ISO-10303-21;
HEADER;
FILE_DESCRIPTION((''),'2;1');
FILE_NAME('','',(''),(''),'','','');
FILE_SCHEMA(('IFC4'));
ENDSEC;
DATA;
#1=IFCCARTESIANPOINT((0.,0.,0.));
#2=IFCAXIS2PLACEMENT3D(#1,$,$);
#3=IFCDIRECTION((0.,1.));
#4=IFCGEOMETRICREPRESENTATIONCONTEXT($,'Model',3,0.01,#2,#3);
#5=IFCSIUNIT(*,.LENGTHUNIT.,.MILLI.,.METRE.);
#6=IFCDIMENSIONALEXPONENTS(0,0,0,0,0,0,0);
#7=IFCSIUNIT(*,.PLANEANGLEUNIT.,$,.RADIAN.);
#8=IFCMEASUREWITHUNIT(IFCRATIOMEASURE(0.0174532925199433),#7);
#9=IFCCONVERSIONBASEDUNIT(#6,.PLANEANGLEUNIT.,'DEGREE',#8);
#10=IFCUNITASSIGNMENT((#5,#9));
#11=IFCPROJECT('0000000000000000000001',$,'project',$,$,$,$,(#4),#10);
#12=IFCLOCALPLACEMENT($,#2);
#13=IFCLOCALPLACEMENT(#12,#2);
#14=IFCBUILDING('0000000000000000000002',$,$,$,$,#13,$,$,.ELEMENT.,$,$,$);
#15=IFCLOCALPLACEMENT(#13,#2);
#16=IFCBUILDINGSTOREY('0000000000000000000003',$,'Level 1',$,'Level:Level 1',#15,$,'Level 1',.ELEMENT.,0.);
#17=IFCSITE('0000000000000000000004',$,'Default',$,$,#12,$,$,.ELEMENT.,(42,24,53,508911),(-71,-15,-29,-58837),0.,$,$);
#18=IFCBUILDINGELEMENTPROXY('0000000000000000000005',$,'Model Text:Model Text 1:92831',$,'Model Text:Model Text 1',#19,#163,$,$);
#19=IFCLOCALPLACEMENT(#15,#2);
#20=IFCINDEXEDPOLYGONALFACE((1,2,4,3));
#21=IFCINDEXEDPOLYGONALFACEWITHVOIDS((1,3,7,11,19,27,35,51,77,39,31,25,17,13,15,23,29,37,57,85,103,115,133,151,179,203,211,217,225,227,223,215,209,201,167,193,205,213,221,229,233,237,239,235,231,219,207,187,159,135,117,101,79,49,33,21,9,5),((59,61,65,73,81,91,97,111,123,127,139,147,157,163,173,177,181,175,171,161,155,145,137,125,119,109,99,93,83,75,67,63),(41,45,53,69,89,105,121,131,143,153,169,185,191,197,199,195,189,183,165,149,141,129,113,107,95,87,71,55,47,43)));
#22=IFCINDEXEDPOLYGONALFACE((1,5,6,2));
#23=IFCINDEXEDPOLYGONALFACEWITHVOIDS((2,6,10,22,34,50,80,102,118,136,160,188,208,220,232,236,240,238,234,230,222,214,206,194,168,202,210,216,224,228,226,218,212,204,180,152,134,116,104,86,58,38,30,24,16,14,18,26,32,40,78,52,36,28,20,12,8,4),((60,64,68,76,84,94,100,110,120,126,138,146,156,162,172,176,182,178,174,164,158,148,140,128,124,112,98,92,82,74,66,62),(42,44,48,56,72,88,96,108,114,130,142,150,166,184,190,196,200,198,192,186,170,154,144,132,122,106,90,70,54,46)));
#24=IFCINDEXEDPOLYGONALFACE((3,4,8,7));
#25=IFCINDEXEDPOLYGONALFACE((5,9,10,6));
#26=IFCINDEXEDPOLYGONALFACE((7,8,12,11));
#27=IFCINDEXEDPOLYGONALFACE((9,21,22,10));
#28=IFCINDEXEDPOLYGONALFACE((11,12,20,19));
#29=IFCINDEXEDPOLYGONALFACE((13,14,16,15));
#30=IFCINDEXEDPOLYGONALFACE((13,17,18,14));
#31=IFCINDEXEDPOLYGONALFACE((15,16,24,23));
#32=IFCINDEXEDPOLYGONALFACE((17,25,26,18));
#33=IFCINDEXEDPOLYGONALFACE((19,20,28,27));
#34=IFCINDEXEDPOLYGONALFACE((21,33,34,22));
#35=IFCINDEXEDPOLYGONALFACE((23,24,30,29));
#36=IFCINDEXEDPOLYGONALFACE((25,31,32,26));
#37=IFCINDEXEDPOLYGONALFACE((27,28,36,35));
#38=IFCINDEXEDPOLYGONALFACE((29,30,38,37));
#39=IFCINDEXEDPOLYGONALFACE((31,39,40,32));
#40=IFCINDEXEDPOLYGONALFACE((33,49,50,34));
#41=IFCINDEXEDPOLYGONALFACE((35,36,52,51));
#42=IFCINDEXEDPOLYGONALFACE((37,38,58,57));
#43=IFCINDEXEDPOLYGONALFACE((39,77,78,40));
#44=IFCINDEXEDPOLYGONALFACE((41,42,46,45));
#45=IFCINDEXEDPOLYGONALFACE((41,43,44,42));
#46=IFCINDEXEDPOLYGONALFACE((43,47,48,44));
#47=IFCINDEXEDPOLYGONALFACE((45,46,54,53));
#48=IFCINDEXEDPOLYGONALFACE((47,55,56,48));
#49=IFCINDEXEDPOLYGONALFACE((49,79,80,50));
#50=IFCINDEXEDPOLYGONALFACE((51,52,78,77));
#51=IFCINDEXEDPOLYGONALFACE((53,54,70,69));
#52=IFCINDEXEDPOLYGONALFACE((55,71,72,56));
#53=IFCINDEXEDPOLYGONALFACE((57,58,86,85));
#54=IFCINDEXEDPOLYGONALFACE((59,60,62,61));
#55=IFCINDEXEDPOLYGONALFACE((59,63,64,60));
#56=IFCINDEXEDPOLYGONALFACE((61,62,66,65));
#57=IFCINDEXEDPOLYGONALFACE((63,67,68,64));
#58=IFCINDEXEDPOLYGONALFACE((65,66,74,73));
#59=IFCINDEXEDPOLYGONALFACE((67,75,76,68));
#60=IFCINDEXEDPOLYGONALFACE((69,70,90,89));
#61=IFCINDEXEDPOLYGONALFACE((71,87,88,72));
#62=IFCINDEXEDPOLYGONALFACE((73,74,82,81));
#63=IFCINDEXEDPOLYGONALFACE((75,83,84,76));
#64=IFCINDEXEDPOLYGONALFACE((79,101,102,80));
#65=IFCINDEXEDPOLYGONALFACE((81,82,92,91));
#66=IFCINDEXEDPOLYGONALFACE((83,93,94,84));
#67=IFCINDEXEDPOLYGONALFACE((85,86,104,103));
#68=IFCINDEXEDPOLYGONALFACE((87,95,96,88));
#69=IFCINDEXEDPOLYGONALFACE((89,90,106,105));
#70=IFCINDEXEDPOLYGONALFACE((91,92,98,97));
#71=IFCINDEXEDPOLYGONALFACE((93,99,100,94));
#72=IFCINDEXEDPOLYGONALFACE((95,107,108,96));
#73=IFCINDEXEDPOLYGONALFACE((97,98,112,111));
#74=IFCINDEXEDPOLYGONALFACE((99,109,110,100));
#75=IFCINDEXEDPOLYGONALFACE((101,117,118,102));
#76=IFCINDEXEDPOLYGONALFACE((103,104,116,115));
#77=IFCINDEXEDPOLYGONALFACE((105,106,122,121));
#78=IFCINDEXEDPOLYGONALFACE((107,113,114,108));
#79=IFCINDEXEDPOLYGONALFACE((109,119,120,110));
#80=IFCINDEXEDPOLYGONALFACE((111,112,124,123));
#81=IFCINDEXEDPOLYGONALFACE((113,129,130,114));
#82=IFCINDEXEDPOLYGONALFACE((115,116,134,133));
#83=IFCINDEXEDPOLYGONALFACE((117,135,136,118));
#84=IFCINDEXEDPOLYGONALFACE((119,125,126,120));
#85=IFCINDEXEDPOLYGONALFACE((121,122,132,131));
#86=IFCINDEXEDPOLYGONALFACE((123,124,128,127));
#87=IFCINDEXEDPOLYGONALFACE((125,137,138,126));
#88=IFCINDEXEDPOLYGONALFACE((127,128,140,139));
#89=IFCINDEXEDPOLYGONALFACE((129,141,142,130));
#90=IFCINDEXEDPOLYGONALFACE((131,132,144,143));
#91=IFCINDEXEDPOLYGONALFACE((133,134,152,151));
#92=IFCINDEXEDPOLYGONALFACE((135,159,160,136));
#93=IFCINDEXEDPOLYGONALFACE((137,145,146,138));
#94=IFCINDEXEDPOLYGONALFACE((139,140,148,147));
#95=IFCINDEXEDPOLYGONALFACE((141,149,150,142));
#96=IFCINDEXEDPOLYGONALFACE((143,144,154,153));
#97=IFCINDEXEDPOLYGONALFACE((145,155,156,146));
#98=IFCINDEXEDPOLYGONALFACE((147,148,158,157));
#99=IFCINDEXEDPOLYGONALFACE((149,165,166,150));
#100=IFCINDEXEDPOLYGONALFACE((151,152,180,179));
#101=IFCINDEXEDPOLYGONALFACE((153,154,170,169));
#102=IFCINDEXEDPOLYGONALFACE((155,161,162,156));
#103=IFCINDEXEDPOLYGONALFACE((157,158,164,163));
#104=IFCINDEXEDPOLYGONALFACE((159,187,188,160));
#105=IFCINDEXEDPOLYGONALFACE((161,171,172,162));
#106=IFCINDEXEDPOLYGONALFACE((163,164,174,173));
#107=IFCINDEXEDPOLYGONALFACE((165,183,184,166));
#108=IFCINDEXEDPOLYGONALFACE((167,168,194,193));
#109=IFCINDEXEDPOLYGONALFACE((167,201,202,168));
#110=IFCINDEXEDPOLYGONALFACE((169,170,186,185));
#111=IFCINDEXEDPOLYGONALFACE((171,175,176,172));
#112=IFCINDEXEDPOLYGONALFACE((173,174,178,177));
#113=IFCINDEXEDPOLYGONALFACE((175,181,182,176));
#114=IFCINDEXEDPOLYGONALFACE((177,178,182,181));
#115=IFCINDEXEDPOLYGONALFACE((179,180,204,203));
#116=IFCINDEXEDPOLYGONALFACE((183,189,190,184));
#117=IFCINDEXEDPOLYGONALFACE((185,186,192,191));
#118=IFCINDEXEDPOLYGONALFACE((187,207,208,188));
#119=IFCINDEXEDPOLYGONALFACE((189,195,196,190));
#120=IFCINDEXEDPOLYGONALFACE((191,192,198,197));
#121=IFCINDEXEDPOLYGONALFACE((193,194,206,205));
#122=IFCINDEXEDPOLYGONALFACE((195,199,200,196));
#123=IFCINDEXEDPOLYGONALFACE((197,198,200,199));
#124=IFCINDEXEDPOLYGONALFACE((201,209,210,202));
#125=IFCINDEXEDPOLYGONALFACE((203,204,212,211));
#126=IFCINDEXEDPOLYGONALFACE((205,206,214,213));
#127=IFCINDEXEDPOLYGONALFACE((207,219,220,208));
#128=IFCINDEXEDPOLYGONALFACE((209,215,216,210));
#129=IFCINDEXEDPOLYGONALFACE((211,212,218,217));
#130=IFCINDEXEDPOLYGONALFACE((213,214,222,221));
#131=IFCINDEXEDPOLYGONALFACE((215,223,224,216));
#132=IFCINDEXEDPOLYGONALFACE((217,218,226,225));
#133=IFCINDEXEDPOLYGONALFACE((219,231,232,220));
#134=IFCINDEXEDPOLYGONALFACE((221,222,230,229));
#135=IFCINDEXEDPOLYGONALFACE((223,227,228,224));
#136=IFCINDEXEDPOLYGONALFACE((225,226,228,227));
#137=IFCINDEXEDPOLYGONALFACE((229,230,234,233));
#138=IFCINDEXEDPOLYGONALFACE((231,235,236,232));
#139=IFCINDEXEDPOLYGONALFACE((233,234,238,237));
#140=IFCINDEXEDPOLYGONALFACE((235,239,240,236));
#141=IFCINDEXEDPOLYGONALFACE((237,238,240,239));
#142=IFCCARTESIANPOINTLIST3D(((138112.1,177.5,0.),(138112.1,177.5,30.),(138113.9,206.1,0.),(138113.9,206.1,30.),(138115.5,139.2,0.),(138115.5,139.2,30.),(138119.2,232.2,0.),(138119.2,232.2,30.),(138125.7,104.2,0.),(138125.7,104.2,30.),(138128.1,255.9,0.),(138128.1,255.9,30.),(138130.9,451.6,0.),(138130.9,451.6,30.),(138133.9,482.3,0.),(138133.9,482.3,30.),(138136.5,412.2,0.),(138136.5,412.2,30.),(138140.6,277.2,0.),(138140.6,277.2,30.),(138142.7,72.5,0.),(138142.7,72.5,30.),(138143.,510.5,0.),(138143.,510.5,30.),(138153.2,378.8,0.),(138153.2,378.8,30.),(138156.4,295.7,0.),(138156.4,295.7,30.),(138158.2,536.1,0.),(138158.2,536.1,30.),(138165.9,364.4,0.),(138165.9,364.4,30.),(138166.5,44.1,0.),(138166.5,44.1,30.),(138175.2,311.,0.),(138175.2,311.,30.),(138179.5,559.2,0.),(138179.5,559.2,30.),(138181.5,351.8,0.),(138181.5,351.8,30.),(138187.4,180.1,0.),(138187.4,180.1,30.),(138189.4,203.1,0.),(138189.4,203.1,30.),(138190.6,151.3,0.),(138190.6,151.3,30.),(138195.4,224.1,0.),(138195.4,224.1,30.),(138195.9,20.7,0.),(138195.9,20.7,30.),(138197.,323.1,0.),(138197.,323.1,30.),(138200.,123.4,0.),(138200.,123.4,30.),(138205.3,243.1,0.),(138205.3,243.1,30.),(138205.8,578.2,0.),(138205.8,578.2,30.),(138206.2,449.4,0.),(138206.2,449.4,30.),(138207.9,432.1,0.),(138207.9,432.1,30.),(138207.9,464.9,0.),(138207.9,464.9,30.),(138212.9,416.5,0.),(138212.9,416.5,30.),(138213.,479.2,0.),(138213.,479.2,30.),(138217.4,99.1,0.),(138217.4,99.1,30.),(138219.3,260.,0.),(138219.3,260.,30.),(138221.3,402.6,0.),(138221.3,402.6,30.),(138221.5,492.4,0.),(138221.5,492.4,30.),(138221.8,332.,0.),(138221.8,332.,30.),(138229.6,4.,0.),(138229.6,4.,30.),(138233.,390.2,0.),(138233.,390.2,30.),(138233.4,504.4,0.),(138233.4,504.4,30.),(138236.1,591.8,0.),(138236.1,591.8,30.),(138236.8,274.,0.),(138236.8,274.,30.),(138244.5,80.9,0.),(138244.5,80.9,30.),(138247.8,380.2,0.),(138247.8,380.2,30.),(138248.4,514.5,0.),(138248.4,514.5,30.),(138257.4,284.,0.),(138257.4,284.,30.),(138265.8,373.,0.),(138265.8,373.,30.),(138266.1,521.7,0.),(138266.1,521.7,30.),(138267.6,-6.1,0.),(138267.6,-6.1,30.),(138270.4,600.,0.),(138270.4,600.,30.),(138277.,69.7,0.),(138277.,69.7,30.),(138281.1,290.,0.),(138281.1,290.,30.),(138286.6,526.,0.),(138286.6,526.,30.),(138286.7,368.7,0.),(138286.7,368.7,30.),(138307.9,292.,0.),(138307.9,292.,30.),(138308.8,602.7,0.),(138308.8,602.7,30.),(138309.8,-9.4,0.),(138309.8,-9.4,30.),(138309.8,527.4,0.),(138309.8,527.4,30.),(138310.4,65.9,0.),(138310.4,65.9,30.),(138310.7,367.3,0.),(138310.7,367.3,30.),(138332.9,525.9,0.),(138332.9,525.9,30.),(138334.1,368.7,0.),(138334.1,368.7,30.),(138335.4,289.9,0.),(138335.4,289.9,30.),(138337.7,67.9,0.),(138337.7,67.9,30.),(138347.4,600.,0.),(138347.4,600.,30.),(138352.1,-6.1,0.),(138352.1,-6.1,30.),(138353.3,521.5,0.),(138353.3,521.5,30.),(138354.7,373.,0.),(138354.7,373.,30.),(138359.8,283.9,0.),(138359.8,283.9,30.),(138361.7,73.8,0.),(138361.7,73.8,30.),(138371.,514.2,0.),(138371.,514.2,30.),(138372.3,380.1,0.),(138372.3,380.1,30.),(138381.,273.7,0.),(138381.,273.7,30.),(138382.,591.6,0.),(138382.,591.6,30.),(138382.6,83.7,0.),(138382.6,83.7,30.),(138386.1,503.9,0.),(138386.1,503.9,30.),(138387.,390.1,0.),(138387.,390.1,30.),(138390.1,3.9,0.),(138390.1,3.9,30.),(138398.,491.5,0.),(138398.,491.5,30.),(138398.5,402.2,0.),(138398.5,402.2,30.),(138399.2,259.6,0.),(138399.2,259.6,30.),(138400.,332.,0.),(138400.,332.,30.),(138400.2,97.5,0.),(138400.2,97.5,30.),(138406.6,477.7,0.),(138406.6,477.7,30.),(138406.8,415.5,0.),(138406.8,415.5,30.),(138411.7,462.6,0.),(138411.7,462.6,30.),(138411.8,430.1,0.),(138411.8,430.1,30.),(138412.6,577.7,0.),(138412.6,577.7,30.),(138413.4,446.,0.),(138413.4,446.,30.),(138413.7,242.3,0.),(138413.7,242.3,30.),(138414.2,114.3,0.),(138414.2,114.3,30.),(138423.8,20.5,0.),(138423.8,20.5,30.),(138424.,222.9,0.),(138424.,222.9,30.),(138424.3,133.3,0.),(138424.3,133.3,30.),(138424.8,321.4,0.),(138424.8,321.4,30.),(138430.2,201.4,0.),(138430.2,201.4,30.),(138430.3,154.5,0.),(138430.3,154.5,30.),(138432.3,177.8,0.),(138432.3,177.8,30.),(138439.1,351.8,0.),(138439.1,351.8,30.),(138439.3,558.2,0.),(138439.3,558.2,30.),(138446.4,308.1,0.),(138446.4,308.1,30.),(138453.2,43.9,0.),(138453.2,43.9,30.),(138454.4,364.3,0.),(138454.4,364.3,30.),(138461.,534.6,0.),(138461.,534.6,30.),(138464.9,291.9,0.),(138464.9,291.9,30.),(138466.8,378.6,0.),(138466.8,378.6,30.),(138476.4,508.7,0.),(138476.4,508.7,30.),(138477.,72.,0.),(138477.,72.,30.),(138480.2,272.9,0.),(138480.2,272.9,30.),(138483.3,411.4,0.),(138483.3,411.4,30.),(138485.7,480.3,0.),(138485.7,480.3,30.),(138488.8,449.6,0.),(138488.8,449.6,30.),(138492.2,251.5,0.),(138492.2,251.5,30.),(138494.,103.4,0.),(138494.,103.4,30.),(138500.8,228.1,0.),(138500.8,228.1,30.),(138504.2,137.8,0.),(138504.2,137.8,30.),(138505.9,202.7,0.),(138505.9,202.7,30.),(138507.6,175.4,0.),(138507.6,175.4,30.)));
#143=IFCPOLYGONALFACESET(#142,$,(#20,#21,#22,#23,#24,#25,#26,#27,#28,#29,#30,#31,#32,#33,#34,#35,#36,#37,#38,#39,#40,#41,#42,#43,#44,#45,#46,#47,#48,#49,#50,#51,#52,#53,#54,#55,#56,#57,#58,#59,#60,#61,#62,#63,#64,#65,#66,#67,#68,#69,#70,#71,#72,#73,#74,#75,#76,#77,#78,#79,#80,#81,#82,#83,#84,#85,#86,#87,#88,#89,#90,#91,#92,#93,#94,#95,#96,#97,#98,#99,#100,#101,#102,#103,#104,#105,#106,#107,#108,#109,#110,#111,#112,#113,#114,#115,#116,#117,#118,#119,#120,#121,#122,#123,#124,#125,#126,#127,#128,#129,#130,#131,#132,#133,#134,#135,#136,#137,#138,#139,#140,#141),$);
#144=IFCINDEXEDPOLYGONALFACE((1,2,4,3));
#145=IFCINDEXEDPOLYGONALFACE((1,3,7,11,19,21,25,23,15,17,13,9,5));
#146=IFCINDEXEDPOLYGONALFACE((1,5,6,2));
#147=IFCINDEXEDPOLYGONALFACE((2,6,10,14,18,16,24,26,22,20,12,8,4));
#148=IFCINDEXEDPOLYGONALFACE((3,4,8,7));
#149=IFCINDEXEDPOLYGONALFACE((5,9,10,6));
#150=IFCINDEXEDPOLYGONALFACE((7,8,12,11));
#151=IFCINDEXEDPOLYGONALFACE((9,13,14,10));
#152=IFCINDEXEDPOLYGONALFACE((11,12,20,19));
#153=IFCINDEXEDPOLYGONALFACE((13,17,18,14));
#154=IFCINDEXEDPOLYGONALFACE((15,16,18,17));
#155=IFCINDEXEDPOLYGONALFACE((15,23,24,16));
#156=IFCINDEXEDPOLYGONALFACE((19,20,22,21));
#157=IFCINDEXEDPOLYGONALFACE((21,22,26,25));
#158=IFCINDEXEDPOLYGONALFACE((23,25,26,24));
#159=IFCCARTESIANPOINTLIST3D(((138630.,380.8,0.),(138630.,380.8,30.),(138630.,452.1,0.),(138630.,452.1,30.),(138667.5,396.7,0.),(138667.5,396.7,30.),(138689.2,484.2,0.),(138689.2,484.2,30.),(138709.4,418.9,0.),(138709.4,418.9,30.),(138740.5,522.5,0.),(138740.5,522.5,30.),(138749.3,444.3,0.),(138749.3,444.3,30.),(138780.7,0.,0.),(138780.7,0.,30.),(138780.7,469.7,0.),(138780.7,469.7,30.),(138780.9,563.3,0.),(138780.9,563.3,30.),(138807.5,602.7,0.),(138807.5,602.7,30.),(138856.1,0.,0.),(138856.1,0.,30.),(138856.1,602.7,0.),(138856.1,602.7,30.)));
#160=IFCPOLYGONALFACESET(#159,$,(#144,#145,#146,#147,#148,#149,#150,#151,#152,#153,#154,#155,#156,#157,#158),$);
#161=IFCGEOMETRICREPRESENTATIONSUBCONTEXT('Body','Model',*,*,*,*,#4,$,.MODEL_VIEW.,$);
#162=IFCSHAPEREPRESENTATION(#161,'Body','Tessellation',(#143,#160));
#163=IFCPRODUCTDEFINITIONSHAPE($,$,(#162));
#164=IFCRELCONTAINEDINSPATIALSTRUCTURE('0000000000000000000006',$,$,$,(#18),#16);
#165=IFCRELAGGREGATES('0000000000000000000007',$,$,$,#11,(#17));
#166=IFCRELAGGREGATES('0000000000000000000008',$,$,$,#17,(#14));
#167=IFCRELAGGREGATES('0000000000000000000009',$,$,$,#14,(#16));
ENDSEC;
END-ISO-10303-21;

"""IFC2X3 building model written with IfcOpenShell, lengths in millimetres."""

from ifc_helpers import new_model, entity, si_unit, converted_unit, direction, frame, origin, place, context, subcontext, project, spatial, polyline, outline, extrude, element, save


model = new_model("IFC2X3")

# Units and contexts
model_context = context("Model", 3, precision=0.01, world=origin(), true_north=direction((0.0, 1.0)))
body_context = subcontext(model_context, "Body", "Model", "MODEL_VIEW")
ifc_project = project(units=[si_unit("LENGTHUNIT", "METRE", prefix="MILLI"), converted_unit("PLANEANGLEUNIT", "DEGREE", entity("IfcRatioMeasure", 0.0174532925199433), si_unit("PLANEANGLEUNIT", "RADIAN"), dimensions=[0, 0, 0, 0, 0, 0, 0])], contexts=[model_context])

# Site, building, storey
site_placement = place(None, origin())
site = spatial("IfcSite", under=ifc_project, at=site_placement, Name="Default", CompositionType="ELEMENT", RefLatitude=(42, 24, 53, 508911), RefLongitude=(-71, -15, -29, -58837), RefElevation=0.0)
building_placement = place(site_placement, origin())
building = spatial("IfcBuilding", under=site, at=building_placement, CompositionType="ELEMENT")
storey_placement = place(building_placement, origin())
storey = spatial("IfcBuildingStorey", under=building, at=storey_placement, Name="Level 1", ObjectType="Level:Level 1", LongName="Level 1", CompositionType="ELEMENT", Elevation=0.0)

# Building element proxy
proxy_1_placement = place(storey_placement, origin())
element("IfcBuildingElementProxy", 1, at=proxy_1_placement, inside=storey, Name="Model Text:Model Text 1:92831", ObjectType="Model Text:Model Text 1", context=body_context, shape_type="SweptSolid", body=[
    extrude(outline(polyline([(74.3, -53.8), (100.6, -53.8), (125.3, -49.8), (148.1, -41.8), (169.2, -29.7), (188.1, -13.8), (204.5, 5.5), (218.4, 28.3), (229.7, 54.7), (239.4, 91.9), (241.6, 128.3), (236.2, 163.8), (223.4, 198.6), (203.6, 230.5), (177.5, 257.6), (145.1, 279.9), (106.4, 297.2), (65.5, 308.4), (26.4, 311.7), (-11.0, 307.4), (-46.5, 295.4), (-78.4, 276.8), (-105.0, 253.1), (-126.2, 224.1), (-142.0, 189.8), (-149.6, 163.5), (-153.3, 137.9), (-153.1, 113.0), (-149.0, 88.8), (-141.0, 65.8), (-129.1, 44.3), (-113.3, 24.5), (-93.5, 6.2), (-137.0, 0.7), (-155.5, -5.9), (-172.0, -15.2), (-198.6, -40.6), (-216.7, -74.6), (-224.1, -104.7), (-225.0, -134.5), (-219.1, -164.1), (-206.7, -193.5), (-188.1, -220.9), (-164.0, -244.3), (-134.2, -263.9), (-98.8, -279.5), (-61.8, -289.8), (-26.7, -293.7), (6.5, -291.1), (37.6, -282.0), (65.4, -267.5), (88.3, -248.5), (106.4, -225.0), (119.6, -197.1), (127.6, -158.1), (123.1, -121.0), (116.1, -103.3), (105.6, -86.1), (74.3, -53.8)]), holes=[polyline([(49.4, -169.7), (42.6, -183.7), (33.0, -195.4), (20.5, -205.0), (5.3, -212.3), (-12.2, -216.7), (-31.3, -217.5), (-52.0, -214.7), (-74.4, -208.2), (-95.6, -199.0), (-113.4, -188.0), (-127.6, -175.1), (-138.3, -160.4), (-145.4, -144.7), (-148.8, -128.8), (-148.5, -112.8), (-144.5, -96.7), (-137.6, -82.3), (-128.0, -70.2), (-115.7, -60.4), (-100.8, -52.9), (-83.6, -48.5), (-64.6, -47.7), (-43.8, -50.6), (-21.3, -57.2), (0.8, -66.6), (19.1, -77.7), (33.6, -90.5), (44.2, -105.0), (51.0, -120.5), (54.2, -136.4), (53.7, -152.8), (49.4, -169.7)]), polyline([(157.9, 77.5), (148.2, 56.6), (135.5, 38.8), (119.8, 24.3), (100.9, 13.0), (79.8, 5.8), (57.0, 3.3), (32.7, 5.7), (6.7, 12.8), (-18.5, 24.0), (-39.4, 37.9), (-56.0, 54.6), (-68.3, 74.1), (-76.1, 95.2), (-79.3, 116.9), (-77.9, 139.3), (-71.9, 162.2), (-62.2, 183.5), (-49.4, 201.4), (-33.6, 215.9), (-14.7, 227.0), (6.6, 234.1), (29.5, 236.4), (54.2, 233.8), (80.5, 226.5), (110.7, 211.7), (137.5, 190.2), (156.9, 164.0), (165.1, 135.2), (164.6, 105.7), (157.9, 77.5)])]), frame((138309.9, 306.3, 0.0), z_axis=(0.0, 0.0, 1.0), x_axis=(-0.941552, -0.336867, 0.0)), (0.0, 0.0, 1.0), 30.0),
    extrude(outline(polyline([(-410.6, -111.6), (192.1, -111.6), (192.1, -63.1), (152.7, -36.4), (111.9, 4.0), (73.6, 55.2), (41.4, 114.4), (-29.8, 114.4), (-13.9, 77.0), (8.3, 35.1), (33.7, -4.8), (59.1, -36.3), (-410.6, -36.3), (-410.6, -111.6)])), frame((138744.5, 410.6, 0.0), z_axis=(0.0, 0.0, 1.0), x_axis=(0.0, 1.0, 0.0)), (0.0, 0.0, 1.0), 30.0),
])

save(model, "model.ifc")
